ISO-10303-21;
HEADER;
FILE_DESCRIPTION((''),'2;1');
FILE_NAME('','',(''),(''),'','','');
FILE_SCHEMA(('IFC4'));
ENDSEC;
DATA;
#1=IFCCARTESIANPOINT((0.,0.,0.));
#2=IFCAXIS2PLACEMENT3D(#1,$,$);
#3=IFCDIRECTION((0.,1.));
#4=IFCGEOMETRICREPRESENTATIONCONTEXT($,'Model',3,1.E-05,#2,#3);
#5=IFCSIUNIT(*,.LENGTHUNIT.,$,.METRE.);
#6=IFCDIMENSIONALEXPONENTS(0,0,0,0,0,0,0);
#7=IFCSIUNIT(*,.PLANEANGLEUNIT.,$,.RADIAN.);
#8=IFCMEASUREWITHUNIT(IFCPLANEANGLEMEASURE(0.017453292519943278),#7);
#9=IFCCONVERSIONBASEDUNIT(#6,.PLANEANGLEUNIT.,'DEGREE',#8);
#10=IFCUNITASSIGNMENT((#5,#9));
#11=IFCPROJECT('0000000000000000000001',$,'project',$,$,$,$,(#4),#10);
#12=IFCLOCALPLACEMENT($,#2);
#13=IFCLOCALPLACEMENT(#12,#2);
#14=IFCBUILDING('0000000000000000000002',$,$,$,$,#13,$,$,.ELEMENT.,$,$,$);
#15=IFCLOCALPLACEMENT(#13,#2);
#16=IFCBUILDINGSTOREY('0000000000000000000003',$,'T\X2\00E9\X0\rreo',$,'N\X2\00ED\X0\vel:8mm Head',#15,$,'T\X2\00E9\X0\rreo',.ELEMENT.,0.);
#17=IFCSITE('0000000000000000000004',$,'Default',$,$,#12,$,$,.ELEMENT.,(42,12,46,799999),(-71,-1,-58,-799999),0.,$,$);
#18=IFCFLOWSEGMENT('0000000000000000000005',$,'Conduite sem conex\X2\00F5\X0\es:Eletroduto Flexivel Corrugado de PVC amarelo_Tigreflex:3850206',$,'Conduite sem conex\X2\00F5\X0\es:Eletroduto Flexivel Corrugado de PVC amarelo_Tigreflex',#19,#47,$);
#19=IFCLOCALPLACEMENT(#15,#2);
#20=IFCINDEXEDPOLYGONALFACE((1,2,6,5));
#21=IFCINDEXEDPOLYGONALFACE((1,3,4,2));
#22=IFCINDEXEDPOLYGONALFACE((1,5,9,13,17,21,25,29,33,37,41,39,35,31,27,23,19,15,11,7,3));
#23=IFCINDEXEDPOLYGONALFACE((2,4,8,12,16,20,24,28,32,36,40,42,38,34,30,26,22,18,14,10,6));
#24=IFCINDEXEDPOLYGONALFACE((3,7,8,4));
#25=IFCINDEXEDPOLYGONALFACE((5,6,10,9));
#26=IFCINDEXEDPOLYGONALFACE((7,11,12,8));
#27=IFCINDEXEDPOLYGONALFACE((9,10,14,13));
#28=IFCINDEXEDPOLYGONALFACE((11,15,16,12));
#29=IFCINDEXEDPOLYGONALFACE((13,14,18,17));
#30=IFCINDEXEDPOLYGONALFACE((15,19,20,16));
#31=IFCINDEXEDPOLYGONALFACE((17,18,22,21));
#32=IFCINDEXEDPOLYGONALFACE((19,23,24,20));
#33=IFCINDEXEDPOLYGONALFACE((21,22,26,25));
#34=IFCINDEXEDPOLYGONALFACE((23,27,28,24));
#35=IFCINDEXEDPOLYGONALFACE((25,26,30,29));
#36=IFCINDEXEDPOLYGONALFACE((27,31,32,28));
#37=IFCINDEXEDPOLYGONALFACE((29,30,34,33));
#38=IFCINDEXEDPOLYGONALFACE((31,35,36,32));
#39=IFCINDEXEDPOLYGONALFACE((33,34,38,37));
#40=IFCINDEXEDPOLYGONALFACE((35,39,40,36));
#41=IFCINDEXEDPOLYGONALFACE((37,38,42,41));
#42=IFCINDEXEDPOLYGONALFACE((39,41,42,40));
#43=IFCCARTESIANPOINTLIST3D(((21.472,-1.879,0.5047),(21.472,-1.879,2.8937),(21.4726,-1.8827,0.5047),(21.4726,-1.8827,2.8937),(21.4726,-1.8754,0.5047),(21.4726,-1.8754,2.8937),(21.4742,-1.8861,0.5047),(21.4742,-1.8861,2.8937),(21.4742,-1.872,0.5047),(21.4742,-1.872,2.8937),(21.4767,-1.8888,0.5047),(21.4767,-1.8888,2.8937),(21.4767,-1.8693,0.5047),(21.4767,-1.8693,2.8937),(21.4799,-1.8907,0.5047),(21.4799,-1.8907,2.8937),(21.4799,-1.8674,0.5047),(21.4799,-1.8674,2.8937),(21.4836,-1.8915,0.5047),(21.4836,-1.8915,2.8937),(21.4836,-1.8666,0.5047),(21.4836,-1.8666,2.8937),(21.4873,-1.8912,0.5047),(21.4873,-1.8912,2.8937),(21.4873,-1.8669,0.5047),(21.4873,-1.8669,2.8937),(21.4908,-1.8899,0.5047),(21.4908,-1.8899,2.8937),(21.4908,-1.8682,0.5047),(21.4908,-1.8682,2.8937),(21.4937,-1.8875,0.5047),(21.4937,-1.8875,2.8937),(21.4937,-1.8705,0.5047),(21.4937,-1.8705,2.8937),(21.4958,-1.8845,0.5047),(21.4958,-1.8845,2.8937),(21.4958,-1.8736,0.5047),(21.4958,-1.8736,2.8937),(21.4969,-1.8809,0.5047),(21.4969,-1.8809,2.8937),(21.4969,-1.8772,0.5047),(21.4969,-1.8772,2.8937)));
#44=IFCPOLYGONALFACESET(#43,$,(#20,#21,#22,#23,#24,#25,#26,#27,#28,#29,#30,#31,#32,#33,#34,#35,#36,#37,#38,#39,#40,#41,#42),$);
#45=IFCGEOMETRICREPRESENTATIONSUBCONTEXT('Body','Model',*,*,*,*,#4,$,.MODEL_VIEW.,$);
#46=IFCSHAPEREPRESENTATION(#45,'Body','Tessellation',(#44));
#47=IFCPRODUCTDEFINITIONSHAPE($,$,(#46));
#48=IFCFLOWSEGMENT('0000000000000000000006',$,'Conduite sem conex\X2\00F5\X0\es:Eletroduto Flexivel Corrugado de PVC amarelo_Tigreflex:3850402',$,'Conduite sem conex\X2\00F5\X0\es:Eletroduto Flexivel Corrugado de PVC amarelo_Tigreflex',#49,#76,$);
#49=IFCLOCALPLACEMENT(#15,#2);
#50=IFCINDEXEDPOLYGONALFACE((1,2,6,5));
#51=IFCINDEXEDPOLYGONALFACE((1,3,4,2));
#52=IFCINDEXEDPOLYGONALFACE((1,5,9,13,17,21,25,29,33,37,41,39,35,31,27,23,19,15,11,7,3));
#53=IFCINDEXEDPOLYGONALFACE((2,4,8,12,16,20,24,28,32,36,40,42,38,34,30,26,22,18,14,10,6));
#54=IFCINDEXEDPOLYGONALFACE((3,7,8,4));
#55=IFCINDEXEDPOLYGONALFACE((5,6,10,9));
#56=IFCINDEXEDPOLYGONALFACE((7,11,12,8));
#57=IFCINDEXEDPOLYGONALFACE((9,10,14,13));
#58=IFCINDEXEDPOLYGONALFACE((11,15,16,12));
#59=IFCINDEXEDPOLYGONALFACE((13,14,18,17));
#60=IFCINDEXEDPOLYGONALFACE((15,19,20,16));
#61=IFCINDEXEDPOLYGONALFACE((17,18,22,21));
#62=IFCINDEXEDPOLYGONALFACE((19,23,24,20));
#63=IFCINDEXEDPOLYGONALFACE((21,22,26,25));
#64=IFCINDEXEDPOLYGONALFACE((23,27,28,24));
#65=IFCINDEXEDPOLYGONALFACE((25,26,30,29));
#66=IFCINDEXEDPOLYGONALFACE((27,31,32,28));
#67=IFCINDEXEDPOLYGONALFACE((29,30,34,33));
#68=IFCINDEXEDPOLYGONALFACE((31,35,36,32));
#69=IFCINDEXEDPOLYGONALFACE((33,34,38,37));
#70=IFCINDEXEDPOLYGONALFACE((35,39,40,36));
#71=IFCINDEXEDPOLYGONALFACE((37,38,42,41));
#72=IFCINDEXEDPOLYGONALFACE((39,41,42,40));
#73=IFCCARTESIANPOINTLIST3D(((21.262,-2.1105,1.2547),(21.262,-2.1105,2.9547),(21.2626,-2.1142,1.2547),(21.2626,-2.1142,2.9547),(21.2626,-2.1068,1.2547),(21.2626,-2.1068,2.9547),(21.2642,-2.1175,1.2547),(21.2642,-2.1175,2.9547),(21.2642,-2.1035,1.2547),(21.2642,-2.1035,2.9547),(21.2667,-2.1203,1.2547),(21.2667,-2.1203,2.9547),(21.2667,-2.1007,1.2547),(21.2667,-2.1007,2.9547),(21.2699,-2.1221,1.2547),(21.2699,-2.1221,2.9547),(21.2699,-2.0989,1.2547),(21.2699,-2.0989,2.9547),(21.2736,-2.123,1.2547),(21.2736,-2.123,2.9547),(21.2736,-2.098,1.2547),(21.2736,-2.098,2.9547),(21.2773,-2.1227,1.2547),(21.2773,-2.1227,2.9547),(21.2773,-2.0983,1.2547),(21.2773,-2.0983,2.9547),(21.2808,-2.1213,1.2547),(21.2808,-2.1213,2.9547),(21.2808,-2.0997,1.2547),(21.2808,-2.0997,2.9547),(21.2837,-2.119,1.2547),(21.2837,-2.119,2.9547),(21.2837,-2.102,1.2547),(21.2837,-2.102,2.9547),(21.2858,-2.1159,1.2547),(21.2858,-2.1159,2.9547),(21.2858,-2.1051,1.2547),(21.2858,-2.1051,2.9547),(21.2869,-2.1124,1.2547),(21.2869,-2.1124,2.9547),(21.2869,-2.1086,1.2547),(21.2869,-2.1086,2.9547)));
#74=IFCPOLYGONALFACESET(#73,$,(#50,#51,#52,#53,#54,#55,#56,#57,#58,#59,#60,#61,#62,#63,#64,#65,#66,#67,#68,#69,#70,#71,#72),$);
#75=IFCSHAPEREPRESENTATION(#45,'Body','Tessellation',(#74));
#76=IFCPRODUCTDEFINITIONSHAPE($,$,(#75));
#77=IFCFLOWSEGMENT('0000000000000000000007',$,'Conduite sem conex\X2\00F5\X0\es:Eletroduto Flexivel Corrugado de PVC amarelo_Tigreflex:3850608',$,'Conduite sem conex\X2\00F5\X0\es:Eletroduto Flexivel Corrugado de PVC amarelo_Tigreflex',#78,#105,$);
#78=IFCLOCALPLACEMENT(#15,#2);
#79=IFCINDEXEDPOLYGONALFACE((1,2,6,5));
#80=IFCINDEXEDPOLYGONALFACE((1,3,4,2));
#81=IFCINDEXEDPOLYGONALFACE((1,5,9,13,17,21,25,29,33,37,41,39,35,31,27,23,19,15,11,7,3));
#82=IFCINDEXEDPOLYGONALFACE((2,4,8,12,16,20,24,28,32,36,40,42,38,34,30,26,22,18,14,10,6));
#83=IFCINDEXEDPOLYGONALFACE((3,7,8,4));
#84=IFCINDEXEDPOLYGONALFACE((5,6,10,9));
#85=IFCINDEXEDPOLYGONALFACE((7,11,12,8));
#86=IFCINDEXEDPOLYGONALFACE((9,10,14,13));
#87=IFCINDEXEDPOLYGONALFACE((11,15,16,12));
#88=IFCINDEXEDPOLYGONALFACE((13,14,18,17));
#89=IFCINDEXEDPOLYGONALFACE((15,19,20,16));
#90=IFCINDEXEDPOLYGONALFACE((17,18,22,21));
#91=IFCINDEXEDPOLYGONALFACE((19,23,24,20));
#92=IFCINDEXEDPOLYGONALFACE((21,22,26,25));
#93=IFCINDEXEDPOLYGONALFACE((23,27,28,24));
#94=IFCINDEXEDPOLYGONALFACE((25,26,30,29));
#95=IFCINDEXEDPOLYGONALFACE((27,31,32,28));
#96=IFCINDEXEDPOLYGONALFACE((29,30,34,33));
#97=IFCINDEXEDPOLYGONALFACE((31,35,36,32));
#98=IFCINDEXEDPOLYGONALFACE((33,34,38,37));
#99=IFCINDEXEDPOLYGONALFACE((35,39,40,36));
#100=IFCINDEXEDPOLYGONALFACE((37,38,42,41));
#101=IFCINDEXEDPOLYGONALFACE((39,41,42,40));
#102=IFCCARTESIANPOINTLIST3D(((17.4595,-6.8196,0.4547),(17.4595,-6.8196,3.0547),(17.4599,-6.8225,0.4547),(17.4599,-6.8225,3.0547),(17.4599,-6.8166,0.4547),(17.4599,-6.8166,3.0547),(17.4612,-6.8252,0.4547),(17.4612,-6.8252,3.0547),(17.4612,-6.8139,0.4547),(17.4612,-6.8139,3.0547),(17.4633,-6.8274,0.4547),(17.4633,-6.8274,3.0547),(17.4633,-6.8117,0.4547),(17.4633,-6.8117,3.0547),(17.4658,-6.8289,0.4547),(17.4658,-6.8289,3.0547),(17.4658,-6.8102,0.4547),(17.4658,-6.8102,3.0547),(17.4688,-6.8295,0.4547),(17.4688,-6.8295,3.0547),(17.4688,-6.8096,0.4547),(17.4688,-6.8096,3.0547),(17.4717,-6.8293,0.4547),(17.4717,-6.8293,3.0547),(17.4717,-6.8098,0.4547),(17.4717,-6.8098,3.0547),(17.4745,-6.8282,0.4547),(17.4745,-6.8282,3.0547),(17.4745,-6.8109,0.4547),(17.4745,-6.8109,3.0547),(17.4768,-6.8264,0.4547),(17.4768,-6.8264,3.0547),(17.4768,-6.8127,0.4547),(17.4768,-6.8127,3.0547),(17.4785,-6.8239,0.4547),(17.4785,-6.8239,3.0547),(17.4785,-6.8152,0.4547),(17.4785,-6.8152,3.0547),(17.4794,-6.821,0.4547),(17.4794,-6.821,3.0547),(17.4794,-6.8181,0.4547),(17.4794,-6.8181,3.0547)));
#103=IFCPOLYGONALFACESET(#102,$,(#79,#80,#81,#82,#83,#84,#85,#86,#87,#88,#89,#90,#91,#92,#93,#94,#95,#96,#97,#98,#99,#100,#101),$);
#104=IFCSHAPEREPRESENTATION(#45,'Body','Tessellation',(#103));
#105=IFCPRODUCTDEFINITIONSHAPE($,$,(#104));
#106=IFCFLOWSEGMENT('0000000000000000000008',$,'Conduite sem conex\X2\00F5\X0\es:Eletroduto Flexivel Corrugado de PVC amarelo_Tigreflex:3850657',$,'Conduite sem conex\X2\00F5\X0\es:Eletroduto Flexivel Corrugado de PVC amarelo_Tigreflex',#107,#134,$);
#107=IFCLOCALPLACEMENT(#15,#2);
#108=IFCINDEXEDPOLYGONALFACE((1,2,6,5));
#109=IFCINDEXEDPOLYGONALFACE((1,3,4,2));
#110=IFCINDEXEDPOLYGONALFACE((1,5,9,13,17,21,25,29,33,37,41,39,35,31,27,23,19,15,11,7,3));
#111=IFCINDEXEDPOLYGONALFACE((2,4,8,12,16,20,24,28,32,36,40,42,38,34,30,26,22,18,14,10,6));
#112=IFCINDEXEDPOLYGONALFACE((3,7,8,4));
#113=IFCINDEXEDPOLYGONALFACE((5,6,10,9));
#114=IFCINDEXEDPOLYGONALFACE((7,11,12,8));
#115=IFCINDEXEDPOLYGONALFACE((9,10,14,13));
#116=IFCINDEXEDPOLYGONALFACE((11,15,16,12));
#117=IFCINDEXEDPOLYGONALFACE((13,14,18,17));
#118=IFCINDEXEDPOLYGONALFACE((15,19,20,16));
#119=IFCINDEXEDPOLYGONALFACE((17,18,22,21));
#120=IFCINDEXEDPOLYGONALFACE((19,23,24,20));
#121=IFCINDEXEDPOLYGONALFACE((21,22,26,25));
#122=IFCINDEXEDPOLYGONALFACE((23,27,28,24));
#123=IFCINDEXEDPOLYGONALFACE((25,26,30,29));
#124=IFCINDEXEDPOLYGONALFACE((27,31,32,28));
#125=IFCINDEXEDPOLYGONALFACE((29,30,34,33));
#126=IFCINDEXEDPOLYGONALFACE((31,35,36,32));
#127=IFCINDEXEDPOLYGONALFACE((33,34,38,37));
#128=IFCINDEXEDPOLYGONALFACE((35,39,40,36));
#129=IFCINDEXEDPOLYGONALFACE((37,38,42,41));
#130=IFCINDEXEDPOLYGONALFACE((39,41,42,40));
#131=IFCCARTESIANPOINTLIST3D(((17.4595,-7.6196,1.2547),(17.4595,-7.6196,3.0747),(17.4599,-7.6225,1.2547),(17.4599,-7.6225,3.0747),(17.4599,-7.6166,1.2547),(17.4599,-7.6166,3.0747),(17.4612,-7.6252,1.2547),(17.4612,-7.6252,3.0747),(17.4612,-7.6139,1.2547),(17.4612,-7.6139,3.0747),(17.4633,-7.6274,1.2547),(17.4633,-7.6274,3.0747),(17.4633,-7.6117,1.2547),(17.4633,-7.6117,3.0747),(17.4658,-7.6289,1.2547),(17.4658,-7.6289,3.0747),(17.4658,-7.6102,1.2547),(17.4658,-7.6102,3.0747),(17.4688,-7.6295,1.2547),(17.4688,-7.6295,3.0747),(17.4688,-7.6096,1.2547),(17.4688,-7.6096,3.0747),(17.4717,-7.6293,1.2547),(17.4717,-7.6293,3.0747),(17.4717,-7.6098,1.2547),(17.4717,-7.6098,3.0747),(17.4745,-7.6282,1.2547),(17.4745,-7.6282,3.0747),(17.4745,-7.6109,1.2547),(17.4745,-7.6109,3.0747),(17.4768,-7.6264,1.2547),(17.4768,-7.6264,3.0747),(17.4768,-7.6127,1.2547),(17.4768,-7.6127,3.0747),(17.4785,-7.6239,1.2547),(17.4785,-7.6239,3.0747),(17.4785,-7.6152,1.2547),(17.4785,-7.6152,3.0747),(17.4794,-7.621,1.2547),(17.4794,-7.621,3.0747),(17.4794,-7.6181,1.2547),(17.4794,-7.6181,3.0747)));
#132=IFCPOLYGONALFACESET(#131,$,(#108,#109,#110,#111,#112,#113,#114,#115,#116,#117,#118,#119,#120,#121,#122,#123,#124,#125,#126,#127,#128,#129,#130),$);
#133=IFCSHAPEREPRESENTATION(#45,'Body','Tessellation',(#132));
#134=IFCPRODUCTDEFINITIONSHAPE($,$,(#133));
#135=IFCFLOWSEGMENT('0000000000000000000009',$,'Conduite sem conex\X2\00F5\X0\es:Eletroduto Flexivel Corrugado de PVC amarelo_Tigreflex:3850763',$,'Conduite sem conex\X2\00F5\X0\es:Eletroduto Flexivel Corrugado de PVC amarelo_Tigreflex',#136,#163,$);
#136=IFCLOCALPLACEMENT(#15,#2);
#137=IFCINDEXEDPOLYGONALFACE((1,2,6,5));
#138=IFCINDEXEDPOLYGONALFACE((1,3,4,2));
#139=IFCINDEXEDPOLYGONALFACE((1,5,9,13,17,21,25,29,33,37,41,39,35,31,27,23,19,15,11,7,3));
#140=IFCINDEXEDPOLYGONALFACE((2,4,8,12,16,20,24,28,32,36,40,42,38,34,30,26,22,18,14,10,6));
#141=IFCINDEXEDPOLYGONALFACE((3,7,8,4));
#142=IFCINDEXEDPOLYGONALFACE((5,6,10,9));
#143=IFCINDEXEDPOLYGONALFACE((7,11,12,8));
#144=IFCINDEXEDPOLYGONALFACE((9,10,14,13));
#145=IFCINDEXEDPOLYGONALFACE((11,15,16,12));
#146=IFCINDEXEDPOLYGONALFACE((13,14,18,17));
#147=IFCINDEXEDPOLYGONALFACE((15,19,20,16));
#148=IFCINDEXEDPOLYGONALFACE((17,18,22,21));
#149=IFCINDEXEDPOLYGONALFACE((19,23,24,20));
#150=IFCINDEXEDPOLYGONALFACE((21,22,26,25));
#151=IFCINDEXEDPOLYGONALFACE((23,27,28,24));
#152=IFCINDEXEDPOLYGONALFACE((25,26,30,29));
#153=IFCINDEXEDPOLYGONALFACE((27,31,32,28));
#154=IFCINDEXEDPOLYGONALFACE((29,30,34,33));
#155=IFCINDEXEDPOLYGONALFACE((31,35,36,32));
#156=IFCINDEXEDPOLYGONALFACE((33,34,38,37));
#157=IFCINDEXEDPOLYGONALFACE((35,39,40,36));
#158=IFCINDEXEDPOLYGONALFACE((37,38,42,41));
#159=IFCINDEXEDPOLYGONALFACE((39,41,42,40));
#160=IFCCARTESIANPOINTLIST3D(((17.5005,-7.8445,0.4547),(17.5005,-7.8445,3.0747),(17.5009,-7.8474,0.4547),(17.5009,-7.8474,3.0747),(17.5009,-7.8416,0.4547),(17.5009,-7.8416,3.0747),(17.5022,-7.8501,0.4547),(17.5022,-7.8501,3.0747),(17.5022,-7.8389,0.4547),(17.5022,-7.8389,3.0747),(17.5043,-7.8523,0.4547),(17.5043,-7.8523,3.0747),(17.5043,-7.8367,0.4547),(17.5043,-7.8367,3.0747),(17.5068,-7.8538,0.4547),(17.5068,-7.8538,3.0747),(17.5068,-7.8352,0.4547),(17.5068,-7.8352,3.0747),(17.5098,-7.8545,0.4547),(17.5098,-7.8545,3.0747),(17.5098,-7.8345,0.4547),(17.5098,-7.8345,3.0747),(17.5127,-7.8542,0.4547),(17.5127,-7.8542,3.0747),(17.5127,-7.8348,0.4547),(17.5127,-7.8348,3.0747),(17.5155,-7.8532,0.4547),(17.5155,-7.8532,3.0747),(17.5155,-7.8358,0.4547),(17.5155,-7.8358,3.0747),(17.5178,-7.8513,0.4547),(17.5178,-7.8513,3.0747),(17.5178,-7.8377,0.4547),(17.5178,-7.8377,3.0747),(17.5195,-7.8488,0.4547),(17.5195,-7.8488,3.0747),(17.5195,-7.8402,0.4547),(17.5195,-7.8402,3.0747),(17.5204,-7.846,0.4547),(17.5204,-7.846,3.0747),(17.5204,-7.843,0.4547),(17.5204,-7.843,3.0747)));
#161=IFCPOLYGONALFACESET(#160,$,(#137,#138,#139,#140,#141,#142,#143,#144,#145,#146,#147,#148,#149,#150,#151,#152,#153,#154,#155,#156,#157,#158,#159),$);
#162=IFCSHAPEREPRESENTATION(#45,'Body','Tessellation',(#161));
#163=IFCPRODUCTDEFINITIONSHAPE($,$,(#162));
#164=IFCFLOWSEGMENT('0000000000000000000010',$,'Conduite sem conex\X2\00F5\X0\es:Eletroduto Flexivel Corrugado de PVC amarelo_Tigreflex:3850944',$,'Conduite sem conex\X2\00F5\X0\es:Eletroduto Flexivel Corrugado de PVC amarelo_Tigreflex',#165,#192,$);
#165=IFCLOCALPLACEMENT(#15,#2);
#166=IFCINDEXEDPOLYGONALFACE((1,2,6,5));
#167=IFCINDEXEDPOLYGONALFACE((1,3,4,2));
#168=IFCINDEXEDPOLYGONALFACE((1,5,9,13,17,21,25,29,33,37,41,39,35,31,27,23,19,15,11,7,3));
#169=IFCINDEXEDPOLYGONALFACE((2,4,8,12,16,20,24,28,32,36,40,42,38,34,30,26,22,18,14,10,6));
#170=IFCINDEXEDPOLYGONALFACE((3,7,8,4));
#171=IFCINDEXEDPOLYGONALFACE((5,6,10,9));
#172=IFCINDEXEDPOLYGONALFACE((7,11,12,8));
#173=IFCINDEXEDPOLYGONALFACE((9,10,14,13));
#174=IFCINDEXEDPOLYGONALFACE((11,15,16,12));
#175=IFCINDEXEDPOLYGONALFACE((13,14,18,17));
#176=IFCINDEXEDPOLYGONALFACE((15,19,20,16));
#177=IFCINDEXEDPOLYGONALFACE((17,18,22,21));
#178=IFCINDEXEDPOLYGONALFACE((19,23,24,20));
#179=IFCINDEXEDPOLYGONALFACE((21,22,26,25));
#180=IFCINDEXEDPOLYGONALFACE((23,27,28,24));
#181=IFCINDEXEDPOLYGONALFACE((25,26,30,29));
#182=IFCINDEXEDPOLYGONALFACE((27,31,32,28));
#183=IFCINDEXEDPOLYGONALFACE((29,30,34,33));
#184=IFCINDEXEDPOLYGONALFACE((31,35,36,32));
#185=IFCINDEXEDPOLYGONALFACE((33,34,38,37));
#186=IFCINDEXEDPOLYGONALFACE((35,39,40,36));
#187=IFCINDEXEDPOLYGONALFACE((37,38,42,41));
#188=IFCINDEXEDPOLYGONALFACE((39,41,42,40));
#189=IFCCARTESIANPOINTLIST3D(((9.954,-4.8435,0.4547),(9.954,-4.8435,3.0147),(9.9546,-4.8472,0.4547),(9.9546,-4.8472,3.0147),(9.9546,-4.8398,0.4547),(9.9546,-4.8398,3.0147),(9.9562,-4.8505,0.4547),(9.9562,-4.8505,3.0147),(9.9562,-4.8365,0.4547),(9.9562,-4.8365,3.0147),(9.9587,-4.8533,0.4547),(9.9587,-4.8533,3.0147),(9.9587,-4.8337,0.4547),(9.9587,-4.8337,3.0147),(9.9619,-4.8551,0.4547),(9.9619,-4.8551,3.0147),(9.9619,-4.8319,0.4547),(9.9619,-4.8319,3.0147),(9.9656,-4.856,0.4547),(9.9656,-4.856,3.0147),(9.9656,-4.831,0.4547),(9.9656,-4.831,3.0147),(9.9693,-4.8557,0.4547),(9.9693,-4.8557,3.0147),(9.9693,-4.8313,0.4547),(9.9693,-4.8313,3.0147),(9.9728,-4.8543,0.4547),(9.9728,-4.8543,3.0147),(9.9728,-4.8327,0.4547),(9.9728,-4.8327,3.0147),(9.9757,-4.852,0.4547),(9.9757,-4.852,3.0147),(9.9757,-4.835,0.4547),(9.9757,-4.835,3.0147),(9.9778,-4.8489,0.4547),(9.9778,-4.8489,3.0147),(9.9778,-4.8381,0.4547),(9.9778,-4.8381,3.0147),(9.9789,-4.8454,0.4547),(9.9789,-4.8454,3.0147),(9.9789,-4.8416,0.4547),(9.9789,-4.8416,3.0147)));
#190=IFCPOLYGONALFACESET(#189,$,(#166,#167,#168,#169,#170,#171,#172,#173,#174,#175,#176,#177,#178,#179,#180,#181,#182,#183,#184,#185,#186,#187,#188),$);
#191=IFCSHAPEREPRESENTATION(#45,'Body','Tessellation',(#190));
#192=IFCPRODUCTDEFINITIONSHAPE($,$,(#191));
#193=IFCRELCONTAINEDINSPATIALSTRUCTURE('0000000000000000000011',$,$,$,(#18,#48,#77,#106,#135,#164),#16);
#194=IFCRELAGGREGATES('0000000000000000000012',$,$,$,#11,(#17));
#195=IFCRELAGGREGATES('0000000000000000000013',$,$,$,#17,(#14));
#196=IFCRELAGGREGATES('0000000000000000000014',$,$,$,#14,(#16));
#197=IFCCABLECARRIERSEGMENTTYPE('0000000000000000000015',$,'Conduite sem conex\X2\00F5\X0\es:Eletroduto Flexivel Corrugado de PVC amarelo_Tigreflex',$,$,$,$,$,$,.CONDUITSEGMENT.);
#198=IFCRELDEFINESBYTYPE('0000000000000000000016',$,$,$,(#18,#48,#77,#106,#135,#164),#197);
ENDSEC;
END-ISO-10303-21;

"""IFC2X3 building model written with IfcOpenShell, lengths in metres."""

from ifc_helpers import new_model, entity, si_unit, converted_unit, direction, frame, frame_2d, origin, origin_2d_with_axis, place, context, subcontext, project, spatial, circle, extrude, type_object, element, save


model = new_model("IFC2X3")

# Units and contexts
model_context = context("Model", 3, precision=1e-05, world=origin(), true_north=direction((0.0, 1.0)))
body_context = subcontext(model_context, "Body", "Model", "MODEL_VIEW")
ifc_project = project(units=[si_unit("LENGTHUNIT", "METRE"), converted_unit("PLANEANGLEUNIT", "DEGREE", entity("IfcPlaneAngleMeasure", 0.017453292519943278), si_unit("PLANEANGLEUNIT", "RADIAN"), dimensions=[0, 0, 0, 0, 0, 0, 0])], contexts=[model_context])

# Site, building, storey
site_placement = place(None, origin())
site = spatial("IfcSite", under=ifc_project, at=site_placement, Name="Default", CompositionType="ELEMENT", RefLatitude=(42, 12, 46, 799999), RefLongitude=(-71, -1, -58, -799999), RefElevation=0.0)
building_placement = place(site_placement, origin())
building = spatial("IfcBuilding", under=site, at=building_placement, CompositionType="ELEMENT")
storey_placement = place(building_placement, origin())
storey = spatial("IfcBuildingStorey", under=building, at=storey_placement, Name="Térreo", ObjectType="Nível:8mm Head", LongName="Térreo", CompositionType="ELEMENT", Elevation=0.0)

# Flow segments
cable_carrier_segment_type = type_object("IfcCableCarrierSegmentType", Name="Conduite sem conexões:Eletroduto Flexivel Corrugado de PVC amarelo_Tigreflex", PredefinedType="CONDUITSEGMENT")
flow_segment_1_placement = place(storey_placement, origin())
element("IfcFlowSegment", 1, at=flow_segment_1_placement, inside=storey, type_object=cable_carrier_segment_type, Name="Conduite sem conexões:Eletroduto Flexivel Corrugado de PVC amarelo_Tigreflex:3850206", ObjectType="Conduite sem conexões:Eletroduto Flexivel Corrugado de PVC amarelo_Tigreflex", context=body_context, shape_type="SweptSolid", body=[
    extrude(circle(Radius=0.0125, at=origin_2d_with_axis()), frame((21.4845, -1.879, 0.5047), z_axis=(0.0, 0.0, 1.0), x_axis=(-1.0, 0.0, 0.0)), (0.0, 0.0, 1.0), 2.389),
])
flow_segment_2_placement = place(storey_placement, origin())
element("IfcFlowSegment", 2, at=flow_segment_2_placement, inside=storey, type_object=cable_carrier_segment_type, Name="Conduite sem conexões:Eletroduto Flexivel Corrugado de PVC amarelo_Tigreflex:3850402", ObjectType="Conduite sem conexões:Eletroduto Flexivel Corrugado de PVC amarelo_Tigreflex", context=body_context, shape_type="SweptSolid", body=[
    extrude(circle(Radius=0.0125, at=origin_2d_with_axis()), frame((21.2745, -2.1105, 1.2547), z_axis=(0.0, 0.0, 1.0), x_axis=(-1.0, 0.0, 0.0)), (0.0, 0.0, 1.0), 1.7),
])
flow_segment_3_placement = place(storey_placement, origin())
element("IfcFlowSegment", 3, at=flow_segment_3_placement, inside=storey, type_object=cable_carrier_segment_type, Name="Conduite sem conexões:Eletroduto Flexivel Corrugado de PVC amarelo_Tigreflex:3850608", ObjectType="Conduite sem conexões:Eletroduto Flexivel Corrugado de PVC amarelo_Tigreflex", context=body_context, shape_type="SweptSolid", body=[
    extrude(circle(Radius=0.01, at=frame_2d((0.0, 0.0), x_axis=(1.0, 0.0))), frame((17.4695, -6.8196, 0.4547), z_axis=(0.0, 0.0, 1.0), x_axis=(-1.0, 0.0, 0.0)), (0.0, 0.0, 1.0), 2.6),
])
flow_segment_4_placement = place(storey_placement, origin())
element("IfcFlowSegment", 4, at=flow_segment_4_placement, inside=storey, type_object=cable_carrier_segment_type, Name="Conduite sem conexões:Eletroduto Flexivel Corrugado de PVC amarelo_Tigreflex:3850657", ObjectType="Conduite sem conexões:Eletroduto Flexivel Corrugado de PVC amarelo_Tigreflex", context=body_context, shape_type="SweptSolid", body=[
    extrude(circle(Radius=0.01, at=origin_2d_with_axis()), frame((17.4695, -7.6196, 1.2547), z_axis=(0.0, 0.0, 1.0), x_axis=(-1.0, 0.0, 0.0)), (0.0, 0.0, 1.0), 1.82),
])
flow_segment_5_placement = place(storey_placement, origin())
element("IfcFlowSegment", 5, at=flow_segment_5_placement, inside=storey, type_object=cable_carrier_segment_type, Name="Conduite sem conexões:Eletroduto Flexivel Corrugado de PVC amarelo_Tigreflex:3850763", ObjectType="Conduite sem conexões:Eletroduto Flexivel Corrugado de PVC amarelo_Tigreflex", context=body_context, shape_type="SweptSolid", body=[
    extrude(circle(Radius=0.01, at=origin_2d_with_axis()), frame((17.5105, -7.8445, 0.4547), z_axis=(0.0, 0.0, 1.0), x_axis=(-1.0, 0.0, 0.0)), (0.0, 0.0, 1.0), 2.62),
])
flow_segment_6_placement = place(storey_placement, origin())
element("IfcFlowSegment", 6, at=flow_segment_6_placement, inside=storey, type_object=cable_carrier_segment_type, Name="Conduite sem conexões:Eletroduto Flexivel Corrugado de PVC amarelo_Tigreflex:3850944", ObjectType="Conduite sem conexões:Eletroduto Flexivel Corrugado de PVC amarelo_Tigreflex", context=body_context, shape_type="SweptSolid", body=[
    extrude(circle(Radius=0.0125, at=origin_2d_with_axis()), frame((9.9665, -4.8435, 0.4547), z_axis=(0.0, 0.0, 1.0), x_axis=(-1.0, 0.0, 0.0)), (0.0, 0.0, 1.0), 2.56),
])

save(model, "model.ifc")
